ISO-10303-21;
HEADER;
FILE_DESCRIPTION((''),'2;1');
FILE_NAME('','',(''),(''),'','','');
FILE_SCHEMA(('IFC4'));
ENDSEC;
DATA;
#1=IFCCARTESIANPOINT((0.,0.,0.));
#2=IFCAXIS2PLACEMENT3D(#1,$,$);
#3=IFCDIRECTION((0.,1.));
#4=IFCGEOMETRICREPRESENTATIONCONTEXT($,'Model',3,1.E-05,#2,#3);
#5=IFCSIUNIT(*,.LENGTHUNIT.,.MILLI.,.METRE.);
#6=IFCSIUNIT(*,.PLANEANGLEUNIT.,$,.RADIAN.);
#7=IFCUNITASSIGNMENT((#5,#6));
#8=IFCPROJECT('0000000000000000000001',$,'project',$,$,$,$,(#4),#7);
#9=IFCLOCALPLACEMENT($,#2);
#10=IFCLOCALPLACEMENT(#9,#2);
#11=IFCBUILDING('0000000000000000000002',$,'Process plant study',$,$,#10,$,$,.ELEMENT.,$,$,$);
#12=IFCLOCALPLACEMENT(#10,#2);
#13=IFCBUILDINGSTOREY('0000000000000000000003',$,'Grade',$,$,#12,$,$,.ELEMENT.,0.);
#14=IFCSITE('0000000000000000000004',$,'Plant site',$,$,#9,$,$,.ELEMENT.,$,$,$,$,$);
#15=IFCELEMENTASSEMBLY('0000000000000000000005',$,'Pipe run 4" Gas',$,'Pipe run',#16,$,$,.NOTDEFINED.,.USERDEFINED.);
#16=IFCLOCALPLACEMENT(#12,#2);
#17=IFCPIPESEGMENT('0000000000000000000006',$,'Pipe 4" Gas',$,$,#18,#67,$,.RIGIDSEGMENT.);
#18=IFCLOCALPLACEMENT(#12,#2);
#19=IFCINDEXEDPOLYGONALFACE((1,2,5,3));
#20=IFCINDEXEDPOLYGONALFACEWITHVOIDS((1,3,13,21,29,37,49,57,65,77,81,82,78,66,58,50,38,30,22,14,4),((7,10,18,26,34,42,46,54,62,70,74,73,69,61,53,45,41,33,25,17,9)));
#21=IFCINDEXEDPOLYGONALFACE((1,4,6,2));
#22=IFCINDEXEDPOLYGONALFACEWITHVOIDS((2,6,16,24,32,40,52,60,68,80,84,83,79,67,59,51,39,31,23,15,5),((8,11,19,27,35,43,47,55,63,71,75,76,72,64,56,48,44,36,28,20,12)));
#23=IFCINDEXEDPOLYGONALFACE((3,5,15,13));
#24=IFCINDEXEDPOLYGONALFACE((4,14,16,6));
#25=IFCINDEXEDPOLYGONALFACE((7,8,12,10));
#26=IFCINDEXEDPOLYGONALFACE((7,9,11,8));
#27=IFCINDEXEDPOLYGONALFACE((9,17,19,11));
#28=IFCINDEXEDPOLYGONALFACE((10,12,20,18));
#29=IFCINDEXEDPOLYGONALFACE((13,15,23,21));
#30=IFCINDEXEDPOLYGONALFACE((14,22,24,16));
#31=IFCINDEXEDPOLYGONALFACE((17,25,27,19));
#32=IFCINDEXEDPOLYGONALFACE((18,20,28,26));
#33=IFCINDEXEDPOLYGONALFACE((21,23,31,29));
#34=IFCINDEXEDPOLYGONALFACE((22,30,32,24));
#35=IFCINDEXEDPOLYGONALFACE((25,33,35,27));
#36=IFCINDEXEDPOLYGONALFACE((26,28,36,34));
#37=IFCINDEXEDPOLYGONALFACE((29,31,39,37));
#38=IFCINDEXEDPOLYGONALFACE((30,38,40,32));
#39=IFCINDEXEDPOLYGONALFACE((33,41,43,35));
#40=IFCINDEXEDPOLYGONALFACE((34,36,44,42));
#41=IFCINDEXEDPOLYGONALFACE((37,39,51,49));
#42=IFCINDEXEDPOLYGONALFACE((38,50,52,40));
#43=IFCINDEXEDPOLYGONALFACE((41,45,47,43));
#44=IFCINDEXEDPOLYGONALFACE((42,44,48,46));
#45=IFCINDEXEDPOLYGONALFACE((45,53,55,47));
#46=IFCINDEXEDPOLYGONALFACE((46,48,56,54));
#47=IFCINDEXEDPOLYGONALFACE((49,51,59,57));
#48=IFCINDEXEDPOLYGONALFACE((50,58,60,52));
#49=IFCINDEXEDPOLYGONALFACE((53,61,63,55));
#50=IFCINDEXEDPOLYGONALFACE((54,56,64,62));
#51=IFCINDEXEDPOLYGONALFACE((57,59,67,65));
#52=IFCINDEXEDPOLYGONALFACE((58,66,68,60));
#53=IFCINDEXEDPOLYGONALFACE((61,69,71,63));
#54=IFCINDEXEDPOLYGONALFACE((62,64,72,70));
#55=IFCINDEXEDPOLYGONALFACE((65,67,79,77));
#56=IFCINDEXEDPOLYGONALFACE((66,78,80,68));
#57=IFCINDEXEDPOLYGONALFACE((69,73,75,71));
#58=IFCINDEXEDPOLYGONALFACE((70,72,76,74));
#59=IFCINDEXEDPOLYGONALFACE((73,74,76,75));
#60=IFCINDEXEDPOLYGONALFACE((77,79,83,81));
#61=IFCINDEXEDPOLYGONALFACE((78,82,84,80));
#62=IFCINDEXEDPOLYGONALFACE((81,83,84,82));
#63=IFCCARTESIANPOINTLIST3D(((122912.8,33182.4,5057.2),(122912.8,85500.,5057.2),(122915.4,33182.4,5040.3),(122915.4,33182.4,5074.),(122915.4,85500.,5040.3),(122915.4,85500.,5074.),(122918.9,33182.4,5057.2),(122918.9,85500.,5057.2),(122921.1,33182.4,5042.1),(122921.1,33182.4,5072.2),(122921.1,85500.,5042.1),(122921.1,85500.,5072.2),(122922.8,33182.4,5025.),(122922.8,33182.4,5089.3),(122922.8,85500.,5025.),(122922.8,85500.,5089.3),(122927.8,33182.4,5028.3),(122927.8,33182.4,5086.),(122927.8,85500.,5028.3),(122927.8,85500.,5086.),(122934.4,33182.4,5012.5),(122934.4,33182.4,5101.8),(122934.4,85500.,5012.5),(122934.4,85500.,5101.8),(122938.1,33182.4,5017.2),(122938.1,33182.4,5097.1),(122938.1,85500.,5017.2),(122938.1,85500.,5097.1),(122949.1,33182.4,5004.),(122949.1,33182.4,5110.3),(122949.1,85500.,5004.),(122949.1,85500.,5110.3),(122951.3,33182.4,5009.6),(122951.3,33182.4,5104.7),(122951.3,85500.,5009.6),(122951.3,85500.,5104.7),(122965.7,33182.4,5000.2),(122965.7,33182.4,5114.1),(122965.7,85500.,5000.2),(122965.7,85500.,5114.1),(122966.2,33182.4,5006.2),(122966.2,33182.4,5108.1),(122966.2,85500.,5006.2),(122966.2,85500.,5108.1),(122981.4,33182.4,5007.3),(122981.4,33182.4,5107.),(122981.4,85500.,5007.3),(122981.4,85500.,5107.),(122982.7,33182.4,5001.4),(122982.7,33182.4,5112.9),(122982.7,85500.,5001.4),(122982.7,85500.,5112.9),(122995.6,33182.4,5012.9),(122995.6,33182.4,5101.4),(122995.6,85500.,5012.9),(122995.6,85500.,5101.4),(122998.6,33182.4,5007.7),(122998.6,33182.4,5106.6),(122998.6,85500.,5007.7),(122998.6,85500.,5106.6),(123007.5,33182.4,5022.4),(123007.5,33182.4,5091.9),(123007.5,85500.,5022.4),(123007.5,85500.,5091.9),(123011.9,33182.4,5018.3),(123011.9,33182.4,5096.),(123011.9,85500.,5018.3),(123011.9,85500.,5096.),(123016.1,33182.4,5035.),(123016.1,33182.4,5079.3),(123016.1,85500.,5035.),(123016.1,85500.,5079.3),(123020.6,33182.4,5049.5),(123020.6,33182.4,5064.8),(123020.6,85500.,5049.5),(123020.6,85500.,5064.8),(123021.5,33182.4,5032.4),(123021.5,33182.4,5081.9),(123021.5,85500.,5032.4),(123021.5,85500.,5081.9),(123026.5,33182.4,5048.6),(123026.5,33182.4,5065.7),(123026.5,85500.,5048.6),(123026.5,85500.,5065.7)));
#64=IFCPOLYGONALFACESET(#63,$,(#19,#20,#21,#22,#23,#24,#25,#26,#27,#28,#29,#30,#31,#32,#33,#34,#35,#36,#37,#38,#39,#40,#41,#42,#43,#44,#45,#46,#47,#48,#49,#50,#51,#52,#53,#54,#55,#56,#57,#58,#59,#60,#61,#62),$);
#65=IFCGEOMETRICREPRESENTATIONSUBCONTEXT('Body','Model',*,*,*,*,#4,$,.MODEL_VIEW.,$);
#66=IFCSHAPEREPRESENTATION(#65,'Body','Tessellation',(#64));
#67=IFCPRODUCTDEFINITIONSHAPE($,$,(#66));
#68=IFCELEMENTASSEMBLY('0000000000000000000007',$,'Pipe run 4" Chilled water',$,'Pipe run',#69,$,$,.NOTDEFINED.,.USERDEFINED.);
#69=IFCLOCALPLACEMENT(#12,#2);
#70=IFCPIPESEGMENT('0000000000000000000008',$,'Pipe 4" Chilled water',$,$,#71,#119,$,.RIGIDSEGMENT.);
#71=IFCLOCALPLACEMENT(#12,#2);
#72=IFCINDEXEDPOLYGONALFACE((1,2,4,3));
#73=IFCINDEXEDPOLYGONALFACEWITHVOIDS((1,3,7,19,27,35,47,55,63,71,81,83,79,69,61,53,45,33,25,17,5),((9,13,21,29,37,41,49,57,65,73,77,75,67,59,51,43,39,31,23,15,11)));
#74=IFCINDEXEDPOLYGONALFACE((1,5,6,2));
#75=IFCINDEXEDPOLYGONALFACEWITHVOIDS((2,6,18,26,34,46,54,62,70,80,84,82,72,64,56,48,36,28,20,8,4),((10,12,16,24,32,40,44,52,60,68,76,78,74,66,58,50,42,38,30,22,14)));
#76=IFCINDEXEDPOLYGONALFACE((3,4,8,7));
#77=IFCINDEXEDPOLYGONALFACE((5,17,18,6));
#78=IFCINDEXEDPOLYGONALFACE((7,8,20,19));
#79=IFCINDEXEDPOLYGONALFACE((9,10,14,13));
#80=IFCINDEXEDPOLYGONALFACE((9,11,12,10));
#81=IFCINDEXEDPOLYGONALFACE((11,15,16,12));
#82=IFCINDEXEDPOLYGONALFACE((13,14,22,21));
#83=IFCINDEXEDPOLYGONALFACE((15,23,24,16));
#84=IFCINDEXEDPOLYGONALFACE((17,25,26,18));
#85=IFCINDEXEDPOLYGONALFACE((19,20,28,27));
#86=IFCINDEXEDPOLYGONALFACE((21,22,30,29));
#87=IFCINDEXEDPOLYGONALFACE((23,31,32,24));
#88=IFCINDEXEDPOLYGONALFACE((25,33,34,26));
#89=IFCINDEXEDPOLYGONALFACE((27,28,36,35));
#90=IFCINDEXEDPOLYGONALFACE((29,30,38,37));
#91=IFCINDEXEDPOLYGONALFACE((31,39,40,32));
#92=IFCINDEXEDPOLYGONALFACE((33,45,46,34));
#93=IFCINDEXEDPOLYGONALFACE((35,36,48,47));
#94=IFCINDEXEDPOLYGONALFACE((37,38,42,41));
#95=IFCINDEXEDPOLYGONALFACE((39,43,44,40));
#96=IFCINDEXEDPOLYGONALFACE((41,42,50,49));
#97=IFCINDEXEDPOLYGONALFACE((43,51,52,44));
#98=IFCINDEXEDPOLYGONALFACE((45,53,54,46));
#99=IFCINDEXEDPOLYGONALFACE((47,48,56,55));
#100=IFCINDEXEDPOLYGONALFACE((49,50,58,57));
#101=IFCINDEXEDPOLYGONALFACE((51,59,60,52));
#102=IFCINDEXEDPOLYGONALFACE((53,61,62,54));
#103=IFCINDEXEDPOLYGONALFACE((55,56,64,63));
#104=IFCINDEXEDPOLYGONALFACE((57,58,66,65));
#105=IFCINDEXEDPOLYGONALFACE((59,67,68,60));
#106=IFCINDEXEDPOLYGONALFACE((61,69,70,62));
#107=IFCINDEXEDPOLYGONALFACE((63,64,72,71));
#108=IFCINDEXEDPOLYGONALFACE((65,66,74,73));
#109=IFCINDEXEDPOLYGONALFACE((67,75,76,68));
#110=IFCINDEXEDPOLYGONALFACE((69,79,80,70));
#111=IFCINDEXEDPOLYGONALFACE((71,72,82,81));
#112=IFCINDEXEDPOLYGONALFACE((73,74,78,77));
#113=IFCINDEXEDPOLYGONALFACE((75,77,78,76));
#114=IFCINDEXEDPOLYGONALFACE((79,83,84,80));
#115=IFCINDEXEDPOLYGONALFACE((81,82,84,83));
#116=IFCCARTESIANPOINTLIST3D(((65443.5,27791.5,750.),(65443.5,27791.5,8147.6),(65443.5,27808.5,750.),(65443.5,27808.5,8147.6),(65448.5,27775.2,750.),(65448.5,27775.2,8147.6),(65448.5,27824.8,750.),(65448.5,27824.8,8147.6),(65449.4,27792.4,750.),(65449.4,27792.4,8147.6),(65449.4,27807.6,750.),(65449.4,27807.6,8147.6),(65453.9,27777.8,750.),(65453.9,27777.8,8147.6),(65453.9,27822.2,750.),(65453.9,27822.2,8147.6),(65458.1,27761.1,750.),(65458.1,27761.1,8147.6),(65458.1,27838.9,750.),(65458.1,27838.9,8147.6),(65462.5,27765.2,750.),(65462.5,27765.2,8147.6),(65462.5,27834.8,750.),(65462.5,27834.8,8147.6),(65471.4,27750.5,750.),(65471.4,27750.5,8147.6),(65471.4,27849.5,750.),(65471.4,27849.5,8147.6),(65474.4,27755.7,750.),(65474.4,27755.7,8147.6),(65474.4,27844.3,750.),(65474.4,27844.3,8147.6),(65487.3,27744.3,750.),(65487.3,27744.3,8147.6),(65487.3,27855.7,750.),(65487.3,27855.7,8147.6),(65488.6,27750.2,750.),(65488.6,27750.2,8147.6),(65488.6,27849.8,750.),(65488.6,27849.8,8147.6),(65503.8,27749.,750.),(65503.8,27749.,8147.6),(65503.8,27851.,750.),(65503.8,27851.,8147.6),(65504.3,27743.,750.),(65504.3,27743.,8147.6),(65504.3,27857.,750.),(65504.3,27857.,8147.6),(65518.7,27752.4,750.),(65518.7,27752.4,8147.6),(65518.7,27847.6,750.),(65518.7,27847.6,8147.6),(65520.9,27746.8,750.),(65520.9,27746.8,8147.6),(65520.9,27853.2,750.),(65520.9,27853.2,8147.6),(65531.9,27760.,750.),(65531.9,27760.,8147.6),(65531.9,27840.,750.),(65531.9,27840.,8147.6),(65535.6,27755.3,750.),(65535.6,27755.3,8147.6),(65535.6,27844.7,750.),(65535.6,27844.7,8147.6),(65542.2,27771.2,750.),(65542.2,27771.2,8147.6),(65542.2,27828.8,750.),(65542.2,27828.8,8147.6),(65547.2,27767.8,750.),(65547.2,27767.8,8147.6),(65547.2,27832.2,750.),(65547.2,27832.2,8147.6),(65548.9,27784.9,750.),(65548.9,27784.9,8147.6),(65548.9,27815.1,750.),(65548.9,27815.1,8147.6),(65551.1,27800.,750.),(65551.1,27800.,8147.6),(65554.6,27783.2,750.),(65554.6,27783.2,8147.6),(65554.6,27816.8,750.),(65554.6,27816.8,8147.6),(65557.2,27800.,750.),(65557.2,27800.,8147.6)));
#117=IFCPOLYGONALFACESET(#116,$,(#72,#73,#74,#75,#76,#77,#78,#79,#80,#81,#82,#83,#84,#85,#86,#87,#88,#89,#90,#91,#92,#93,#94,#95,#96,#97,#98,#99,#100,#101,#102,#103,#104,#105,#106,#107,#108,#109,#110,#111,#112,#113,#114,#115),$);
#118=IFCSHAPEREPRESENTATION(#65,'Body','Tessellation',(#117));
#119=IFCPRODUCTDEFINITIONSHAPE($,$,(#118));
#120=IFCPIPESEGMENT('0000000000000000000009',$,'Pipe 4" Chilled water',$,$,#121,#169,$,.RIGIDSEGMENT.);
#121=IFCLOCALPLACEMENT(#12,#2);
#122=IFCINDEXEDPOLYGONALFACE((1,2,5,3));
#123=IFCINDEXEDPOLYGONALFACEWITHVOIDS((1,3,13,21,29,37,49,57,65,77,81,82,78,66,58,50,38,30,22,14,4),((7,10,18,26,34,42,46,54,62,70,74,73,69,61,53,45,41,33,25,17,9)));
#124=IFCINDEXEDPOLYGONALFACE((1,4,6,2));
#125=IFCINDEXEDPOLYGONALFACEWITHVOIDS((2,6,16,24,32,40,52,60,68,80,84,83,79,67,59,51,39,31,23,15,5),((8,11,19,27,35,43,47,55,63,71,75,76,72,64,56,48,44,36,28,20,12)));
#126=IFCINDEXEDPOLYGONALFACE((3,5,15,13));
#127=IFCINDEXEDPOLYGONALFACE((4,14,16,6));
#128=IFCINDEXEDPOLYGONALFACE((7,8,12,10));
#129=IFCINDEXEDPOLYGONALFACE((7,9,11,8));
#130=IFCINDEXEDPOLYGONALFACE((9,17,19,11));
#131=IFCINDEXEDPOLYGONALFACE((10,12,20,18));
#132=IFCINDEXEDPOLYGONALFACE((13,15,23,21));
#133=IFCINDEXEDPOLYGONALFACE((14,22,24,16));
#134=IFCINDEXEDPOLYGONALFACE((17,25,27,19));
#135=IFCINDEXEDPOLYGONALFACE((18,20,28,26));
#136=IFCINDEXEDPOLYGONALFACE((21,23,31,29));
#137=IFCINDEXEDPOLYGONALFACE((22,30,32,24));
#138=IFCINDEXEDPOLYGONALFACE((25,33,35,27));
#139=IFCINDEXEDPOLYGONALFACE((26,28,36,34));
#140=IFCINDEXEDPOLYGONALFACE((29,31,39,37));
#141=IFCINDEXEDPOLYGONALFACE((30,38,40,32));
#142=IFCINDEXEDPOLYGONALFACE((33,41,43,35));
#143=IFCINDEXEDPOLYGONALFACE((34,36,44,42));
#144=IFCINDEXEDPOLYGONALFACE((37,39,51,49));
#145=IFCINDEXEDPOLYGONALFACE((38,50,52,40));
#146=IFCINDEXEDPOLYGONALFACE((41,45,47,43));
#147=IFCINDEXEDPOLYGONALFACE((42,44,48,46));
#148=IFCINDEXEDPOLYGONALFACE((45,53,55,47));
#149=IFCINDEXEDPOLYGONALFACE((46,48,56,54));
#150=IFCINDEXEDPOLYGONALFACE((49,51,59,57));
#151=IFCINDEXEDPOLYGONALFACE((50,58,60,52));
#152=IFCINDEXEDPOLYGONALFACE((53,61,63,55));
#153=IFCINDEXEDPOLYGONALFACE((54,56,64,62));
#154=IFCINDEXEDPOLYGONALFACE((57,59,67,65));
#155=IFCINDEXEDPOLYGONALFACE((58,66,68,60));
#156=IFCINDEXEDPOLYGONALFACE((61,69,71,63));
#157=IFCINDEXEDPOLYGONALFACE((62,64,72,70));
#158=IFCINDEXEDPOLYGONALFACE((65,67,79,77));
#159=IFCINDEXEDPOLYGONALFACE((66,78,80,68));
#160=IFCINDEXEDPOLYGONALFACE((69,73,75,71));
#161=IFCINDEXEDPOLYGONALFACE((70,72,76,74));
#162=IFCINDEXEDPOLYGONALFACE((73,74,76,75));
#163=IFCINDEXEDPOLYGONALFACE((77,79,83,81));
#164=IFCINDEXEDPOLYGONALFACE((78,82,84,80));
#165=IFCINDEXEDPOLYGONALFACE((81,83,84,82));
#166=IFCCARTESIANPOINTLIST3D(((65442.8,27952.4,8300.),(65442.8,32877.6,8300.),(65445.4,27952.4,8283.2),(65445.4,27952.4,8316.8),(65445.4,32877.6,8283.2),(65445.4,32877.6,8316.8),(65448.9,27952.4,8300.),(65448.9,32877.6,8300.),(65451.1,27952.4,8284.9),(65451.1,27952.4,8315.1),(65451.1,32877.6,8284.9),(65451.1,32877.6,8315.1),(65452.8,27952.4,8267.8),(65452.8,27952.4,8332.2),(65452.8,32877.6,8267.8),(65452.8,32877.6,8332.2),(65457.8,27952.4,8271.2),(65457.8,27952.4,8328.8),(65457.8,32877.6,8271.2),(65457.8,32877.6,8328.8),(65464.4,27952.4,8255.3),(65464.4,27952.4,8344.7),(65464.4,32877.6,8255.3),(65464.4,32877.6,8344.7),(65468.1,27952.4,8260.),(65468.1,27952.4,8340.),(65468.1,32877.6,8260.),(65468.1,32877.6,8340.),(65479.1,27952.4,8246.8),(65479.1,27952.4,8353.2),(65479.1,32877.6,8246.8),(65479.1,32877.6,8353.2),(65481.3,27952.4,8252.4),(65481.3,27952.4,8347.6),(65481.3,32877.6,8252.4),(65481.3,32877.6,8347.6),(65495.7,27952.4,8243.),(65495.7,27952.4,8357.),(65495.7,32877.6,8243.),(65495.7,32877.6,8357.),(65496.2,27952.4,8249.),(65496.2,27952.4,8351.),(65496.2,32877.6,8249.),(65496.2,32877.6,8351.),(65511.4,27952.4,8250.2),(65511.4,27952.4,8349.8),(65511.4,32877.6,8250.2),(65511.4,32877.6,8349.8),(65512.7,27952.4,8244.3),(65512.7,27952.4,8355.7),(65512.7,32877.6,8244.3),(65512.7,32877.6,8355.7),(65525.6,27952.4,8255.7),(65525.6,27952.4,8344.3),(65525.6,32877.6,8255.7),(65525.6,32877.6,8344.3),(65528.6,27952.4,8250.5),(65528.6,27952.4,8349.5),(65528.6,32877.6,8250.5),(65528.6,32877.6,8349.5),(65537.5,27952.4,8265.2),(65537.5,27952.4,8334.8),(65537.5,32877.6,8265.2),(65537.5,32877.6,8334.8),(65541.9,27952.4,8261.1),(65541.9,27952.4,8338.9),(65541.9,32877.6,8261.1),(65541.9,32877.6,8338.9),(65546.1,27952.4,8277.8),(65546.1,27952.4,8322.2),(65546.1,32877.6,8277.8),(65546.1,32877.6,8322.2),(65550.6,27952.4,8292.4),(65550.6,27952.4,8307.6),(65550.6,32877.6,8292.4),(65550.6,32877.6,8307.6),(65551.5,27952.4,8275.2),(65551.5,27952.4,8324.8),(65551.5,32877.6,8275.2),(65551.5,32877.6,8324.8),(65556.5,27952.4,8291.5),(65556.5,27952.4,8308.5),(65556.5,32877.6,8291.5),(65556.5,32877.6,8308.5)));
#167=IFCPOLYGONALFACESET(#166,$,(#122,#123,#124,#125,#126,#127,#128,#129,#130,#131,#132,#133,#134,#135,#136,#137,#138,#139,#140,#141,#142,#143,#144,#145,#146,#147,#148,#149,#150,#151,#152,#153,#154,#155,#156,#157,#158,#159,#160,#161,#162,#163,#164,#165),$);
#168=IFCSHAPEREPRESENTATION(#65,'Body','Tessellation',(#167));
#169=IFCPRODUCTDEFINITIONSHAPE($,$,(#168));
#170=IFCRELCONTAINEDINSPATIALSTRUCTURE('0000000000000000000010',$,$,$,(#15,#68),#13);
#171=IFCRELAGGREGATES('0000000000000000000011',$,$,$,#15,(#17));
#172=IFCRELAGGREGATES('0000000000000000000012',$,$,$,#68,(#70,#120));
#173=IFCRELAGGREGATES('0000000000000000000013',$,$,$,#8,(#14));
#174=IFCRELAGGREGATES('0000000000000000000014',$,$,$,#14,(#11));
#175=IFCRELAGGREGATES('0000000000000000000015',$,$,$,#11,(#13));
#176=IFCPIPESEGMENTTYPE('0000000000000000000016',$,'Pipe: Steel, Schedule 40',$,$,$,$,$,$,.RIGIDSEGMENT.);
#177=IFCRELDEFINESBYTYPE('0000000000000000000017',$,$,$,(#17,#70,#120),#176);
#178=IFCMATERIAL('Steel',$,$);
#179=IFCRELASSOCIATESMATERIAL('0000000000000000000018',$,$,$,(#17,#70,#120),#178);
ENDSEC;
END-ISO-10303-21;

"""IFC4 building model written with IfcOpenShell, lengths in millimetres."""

from ifc_helpers import new_model, si_unit, direction, frame, origin, origin_with_axes, origin_2d, place, context, subcontext, project, spatial, hollow_circle, extrude, material, type_object, element, aggregate, save


model = new_model("IFC4")

# Units and contexts
model_context = context("Model", 3, precision=1e-05, world=origin(), true_north=direction((0.0, 1.0)))
body_context = subcontext(model_context, "Body", "Model", "MODEL_VIEW")
ifc_project = project(units=[si_unit("LENGTHUNIT", "METRE", prefix="MILLI"), si_unit("PLANEANGLEUNIT", "RADIAN")], contexts=[model_context])

# Site, building, storey
site_placement = place(None, origin())
site = spatial("IfcSite", under=ifc_project, at=site_placement, Name="Plant site", CompositionType="ELEMENT")
building_placement = place(site_placement, origin())
building = spatial("IfcBuilding", under=site, at=building_placement, Name="Process plant study", CompositionType="ELEMENT")
storey_placement = place(building_placement, origin())
storey = spatial("IfcBuildingStorey", under=building, at=storey_placement, Name="Grade", CompositionType="ELEMENT", Elevation=0.0)

# Element assembly, pipe segment
assembly_1_placement = place(storey_placement, origin_with_axes())
assembly_1 = element("IfcElementAssembly", 1, at=assembly_1_placement, inside=storey, Name="Pipe run 4\" Gas", ObjectType="Pipe run", AssemblyPlace="NOTDEFINED", PredefinedType="USERDEFINED")
ifc_material = material(Name="Steel")
pipe_segment_type = type_object("IfcPipeSegmentType", Name="Pipe: Steel, Schedule 40", PredefinedType="RIGIDSEGMENT")
pipe_segment_1_placement = place(storey_placement, origin_with_axes())
pipe_segment_1 = element("IfcPipeSegment", 2, at=pipe_segment_1_placement, type_object=pipe_segment_type, material=ifc_material, Name="Pipe 4\" Gas", PredefinedType="RIGIDSEGMENT", context=body_context, shape_type="SweptSolid", body=[
    extrude(hollow_circle(Radius=57.1, WallThickness=6.0, at=origin_2d()), frame((122970.0, 33182.4, 5057.1), z_axis=(0.0, 1.0, 0.0), x_axis=(-1.0, 0.0, 0.0)), (0.0, 0.0, 1.0), 52317.6),
])
aggregate(assembly_1, [pipe_segment_1])

# Element assembly, pipe segments
assembly_2_placement = place(storey_placement, origin_with_axes())
assembly_2 = element("IfcElementAssembly", 3, at=assembly_2_placement, inside=storey, Name="Pipe run 4\" Chilled water", ObjectType="Pipe run", AssemblyPlace="NOTDEFINED", PredefinedType="USERDEFINED")
pipe_segment_2_placement = place(storey_placement, origin_with_axes())
pipe_segment_2 = element("IfcPipeSegment", 4, at=pipe_segment_2_placement, type_object=pipe_segment_type, material=ifc_material, Name="Pipe 4\" Chilled water", PredefinedType="RIGIDSEGMENT", context=body_context, shape_type="SweptSolid", body=[
    extrude(hollow_circle(Radius=57.1, WallThickness=6.0, at=origin_2d()), frame((65500.0, 27800.0, 750.0), z_axis=(0.0, 0.0, 1.0), x_axis=(1.0, 0.0, 0.0)), (0.0, 0.0, 1.0), 7397.6),
])
pipe_segment_3_placement = place(storey_placement, origin_with_axes())
pipe_segment_3 = element("IfcPipeSegment", 5, at=pipe_segment_3_placement, type_object=pipe_segment_type, material=ifc_material, Name="Pipe 4\" Chilled water", PredefinedType="RIGIDSEGMENT", context=body_context, shape_type="SweptSolid", body=[
    extrude(hollow_circle(Radius=57.1, WallThickness=6.0, at=origin_2d()), frame((65500.0, 27952.4, 8300.0), z_axis=(0.0, 1.0, 0.0), x_axis=(-1.0, 0.0, 0.0)), (0.0, 0.0, 1.0), 4925.2),
])

aggregate(assembly_2, [pipe_segment_2, pipe_segment_3])

save(model, "model.ifc")
